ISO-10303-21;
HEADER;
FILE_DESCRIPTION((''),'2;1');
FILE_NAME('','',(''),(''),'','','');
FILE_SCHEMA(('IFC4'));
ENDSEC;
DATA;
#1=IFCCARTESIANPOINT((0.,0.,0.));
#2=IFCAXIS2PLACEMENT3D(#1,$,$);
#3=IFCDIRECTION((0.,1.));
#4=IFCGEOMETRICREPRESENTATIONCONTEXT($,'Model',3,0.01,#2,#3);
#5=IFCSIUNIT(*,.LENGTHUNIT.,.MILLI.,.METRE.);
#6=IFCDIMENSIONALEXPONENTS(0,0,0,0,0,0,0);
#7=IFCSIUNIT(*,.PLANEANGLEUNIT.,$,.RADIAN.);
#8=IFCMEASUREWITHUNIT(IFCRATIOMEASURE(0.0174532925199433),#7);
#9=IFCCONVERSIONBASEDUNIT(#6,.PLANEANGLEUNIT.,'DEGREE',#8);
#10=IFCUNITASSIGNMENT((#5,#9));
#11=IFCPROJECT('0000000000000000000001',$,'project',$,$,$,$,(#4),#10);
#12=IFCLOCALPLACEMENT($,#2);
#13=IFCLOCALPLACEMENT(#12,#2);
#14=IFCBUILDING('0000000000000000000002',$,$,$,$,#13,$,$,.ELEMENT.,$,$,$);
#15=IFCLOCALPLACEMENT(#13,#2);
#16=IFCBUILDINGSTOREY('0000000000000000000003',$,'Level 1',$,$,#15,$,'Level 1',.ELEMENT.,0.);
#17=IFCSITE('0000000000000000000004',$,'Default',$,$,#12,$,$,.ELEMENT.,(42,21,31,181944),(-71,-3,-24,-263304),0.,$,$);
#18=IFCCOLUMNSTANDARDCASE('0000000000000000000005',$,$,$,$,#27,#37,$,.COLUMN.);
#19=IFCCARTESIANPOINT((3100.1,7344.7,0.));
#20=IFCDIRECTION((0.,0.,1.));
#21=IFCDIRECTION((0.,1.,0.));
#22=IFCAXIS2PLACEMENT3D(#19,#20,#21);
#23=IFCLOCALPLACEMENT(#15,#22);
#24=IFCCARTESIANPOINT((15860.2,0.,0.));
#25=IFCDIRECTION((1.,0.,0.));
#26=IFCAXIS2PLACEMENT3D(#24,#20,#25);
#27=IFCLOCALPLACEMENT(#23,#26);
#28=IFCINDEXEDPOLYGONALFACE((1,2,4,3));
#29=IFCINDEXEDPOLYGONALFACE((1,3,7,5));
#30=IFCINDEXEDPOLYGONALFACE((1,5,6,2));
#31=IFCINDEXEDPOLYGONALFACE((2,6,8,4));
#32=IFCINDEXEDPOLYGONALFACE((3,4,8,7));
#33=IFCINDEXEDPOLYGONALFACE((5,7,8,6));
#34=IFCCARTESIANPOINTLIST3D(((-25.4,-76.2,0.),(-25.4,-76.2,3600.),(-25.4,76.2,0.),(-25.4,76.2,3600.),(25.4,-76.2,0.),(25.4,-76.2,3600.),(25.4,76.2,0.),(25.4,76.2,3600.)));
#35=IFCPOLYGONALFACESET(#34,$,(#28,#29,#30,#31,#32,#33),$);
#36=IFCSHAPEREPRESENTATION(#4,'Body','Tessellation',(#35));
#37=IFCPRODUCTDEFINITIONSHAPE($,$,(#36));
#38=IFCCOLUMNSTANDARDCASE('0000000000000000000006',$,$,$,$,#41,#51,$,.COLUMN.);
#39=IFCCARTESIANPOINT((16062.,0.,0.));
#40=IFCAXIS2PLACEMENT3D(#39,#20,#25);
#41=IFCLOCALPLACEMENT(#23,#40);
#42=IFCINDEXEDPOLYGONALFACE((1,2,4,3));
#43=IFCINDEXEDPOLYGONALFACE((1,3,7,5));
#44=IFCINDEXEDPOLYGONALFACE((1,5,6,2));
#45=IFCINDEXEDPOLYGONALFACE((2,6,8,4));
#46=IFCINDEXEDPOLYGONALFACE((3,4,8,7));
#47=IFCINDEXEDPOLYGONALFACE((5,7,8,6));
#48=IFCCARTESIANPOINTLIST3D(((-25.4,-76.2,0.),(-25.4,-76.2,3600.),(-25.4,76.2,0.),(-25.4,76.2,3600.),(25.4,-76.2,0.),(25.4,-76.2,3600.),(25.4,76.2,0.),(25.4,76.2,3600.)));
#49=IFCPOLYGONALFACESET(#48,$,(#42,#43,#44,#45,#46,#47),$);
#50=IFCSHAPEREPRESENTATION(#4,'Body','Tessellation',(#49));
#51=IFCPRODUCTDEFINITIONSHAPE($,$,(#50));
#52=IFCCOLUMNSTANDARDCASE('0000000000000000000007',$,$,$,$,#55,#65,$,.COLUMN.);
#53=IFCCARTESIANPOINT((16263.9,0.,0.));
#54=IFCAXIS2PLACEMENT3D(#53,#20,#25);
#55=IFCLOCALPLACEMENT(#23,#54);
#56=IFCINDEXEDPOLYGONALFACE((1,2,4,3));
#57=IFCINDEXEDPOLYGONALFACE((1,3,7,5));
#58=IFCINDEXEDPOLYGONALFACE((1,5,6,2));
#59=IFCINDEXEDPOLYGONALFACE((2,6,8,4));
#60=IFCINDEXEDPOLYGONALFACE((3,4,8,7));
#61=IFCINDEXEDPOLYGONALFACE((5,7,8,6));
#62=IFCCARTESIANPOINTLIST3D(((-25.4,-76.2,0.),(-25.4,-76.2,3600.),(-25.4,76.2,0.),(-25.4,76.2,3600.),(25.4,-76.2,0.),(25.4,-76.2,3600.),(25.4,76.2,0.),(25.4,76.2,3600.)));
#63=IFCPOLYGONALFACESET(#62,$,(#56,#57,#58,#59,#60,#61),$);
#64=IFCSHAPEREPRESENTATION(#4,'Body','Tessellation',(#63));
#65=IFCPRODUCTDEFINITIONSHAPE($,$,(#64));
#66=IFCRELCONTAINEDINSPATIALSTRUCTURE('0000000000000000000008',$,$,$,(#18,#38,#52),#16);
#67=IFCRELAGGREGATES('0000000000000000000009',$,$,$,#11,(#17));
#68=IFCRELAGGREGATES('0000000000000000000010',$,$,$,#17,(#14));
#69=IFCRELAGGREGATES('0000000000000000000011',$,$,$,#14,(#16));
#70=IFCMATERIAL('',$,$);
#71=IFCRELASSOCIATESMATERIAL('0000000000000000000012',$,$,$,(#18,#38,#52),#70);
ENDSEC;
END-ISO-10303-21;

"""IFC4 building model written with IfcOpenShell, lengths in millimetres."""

from ifc_helpers import new_model, entity, si_unit, converted_unit, direction, frame, origin, place, context, project, spatial, rectangle, extrude, material, element, save


model = new_model("IFC4")

# Units and contexts
model_context = context("Model", 3, precision=0.01, world=origin(), true_north=direction((0.0, 1.0)))
ifc_project = project(units=[si_unit("LENGTHUNIT", "METRE", prefix="MILLI"), converted_unit("PLANEANGLEUNIT", "DEGREE", entity("IfcRatioMeasure", 0.0174532925199433), si_unit("PLANEANGLEUNIT", "RADIAN"), dimensions=[0, 0, 0, 0, 0, 0, 0])], contexts=[model_context])

# Site, building, storey
site_placement = place(None, origin())
site = spatial("IfcSite", under=ifc_project, at=site_placement, Name="Default", CompositionType="ELEMENT", RefLatitude=(42, 21, 31, 181944), RefLongitude=(-71, -3, -24, -263304), RefElevation=0.0)
building_placement = place(site_placement, origin())
building = spatial("IfcBuilding", under=site, at=building_placement, CompositionType="ELEMENT")
storey_placement = place(building_placement, origin())
storey = spatial("IfcBuildingStorey", under=building, at=storey_placement, Name="Level 1", LongName="Level 1", CompositionType="ELEMENT", Elevation=0.0)

# Columns
ifc_material = material(Name="")
placement = place(storey_placement, frame((3100.1, 7344.7, 0.0), z_axis=(0.0, 0.0, 1.0), x_axis=(0.0, 1.0, 0.0)))
for number, where, z_axis, x_axis in (
    (1, (15860.2, 0.0, 0.0), (0.0, 0.0, 1.0), (1.0, 0.0, 0.0)),
    (2, (16062.0, 0.0, 0.0), (0.0, 0.0, 1.0), (1.0, 0.0, 0.0)),
    (3, (16263.9, 0.0, 0.0), (0.0, 0.0, 1.0), (1.0, 0.0, 0.0)),
):
    element("IfcColumnStandardCase", number, at=place(placement, frame(where, z_axis=z_axis, x_axis=x_axis)), inside=storey, material=ifc_material, PredefinedType="COLUMN", context=model_context, shape_type="SweptSolid", body=[
        extrude(rectangle(XDim=50.8, YDim=152.4), origin(), (0.0, 0.0, 1.0), 3600.0),
    ])

save(model, "model.ifc")
